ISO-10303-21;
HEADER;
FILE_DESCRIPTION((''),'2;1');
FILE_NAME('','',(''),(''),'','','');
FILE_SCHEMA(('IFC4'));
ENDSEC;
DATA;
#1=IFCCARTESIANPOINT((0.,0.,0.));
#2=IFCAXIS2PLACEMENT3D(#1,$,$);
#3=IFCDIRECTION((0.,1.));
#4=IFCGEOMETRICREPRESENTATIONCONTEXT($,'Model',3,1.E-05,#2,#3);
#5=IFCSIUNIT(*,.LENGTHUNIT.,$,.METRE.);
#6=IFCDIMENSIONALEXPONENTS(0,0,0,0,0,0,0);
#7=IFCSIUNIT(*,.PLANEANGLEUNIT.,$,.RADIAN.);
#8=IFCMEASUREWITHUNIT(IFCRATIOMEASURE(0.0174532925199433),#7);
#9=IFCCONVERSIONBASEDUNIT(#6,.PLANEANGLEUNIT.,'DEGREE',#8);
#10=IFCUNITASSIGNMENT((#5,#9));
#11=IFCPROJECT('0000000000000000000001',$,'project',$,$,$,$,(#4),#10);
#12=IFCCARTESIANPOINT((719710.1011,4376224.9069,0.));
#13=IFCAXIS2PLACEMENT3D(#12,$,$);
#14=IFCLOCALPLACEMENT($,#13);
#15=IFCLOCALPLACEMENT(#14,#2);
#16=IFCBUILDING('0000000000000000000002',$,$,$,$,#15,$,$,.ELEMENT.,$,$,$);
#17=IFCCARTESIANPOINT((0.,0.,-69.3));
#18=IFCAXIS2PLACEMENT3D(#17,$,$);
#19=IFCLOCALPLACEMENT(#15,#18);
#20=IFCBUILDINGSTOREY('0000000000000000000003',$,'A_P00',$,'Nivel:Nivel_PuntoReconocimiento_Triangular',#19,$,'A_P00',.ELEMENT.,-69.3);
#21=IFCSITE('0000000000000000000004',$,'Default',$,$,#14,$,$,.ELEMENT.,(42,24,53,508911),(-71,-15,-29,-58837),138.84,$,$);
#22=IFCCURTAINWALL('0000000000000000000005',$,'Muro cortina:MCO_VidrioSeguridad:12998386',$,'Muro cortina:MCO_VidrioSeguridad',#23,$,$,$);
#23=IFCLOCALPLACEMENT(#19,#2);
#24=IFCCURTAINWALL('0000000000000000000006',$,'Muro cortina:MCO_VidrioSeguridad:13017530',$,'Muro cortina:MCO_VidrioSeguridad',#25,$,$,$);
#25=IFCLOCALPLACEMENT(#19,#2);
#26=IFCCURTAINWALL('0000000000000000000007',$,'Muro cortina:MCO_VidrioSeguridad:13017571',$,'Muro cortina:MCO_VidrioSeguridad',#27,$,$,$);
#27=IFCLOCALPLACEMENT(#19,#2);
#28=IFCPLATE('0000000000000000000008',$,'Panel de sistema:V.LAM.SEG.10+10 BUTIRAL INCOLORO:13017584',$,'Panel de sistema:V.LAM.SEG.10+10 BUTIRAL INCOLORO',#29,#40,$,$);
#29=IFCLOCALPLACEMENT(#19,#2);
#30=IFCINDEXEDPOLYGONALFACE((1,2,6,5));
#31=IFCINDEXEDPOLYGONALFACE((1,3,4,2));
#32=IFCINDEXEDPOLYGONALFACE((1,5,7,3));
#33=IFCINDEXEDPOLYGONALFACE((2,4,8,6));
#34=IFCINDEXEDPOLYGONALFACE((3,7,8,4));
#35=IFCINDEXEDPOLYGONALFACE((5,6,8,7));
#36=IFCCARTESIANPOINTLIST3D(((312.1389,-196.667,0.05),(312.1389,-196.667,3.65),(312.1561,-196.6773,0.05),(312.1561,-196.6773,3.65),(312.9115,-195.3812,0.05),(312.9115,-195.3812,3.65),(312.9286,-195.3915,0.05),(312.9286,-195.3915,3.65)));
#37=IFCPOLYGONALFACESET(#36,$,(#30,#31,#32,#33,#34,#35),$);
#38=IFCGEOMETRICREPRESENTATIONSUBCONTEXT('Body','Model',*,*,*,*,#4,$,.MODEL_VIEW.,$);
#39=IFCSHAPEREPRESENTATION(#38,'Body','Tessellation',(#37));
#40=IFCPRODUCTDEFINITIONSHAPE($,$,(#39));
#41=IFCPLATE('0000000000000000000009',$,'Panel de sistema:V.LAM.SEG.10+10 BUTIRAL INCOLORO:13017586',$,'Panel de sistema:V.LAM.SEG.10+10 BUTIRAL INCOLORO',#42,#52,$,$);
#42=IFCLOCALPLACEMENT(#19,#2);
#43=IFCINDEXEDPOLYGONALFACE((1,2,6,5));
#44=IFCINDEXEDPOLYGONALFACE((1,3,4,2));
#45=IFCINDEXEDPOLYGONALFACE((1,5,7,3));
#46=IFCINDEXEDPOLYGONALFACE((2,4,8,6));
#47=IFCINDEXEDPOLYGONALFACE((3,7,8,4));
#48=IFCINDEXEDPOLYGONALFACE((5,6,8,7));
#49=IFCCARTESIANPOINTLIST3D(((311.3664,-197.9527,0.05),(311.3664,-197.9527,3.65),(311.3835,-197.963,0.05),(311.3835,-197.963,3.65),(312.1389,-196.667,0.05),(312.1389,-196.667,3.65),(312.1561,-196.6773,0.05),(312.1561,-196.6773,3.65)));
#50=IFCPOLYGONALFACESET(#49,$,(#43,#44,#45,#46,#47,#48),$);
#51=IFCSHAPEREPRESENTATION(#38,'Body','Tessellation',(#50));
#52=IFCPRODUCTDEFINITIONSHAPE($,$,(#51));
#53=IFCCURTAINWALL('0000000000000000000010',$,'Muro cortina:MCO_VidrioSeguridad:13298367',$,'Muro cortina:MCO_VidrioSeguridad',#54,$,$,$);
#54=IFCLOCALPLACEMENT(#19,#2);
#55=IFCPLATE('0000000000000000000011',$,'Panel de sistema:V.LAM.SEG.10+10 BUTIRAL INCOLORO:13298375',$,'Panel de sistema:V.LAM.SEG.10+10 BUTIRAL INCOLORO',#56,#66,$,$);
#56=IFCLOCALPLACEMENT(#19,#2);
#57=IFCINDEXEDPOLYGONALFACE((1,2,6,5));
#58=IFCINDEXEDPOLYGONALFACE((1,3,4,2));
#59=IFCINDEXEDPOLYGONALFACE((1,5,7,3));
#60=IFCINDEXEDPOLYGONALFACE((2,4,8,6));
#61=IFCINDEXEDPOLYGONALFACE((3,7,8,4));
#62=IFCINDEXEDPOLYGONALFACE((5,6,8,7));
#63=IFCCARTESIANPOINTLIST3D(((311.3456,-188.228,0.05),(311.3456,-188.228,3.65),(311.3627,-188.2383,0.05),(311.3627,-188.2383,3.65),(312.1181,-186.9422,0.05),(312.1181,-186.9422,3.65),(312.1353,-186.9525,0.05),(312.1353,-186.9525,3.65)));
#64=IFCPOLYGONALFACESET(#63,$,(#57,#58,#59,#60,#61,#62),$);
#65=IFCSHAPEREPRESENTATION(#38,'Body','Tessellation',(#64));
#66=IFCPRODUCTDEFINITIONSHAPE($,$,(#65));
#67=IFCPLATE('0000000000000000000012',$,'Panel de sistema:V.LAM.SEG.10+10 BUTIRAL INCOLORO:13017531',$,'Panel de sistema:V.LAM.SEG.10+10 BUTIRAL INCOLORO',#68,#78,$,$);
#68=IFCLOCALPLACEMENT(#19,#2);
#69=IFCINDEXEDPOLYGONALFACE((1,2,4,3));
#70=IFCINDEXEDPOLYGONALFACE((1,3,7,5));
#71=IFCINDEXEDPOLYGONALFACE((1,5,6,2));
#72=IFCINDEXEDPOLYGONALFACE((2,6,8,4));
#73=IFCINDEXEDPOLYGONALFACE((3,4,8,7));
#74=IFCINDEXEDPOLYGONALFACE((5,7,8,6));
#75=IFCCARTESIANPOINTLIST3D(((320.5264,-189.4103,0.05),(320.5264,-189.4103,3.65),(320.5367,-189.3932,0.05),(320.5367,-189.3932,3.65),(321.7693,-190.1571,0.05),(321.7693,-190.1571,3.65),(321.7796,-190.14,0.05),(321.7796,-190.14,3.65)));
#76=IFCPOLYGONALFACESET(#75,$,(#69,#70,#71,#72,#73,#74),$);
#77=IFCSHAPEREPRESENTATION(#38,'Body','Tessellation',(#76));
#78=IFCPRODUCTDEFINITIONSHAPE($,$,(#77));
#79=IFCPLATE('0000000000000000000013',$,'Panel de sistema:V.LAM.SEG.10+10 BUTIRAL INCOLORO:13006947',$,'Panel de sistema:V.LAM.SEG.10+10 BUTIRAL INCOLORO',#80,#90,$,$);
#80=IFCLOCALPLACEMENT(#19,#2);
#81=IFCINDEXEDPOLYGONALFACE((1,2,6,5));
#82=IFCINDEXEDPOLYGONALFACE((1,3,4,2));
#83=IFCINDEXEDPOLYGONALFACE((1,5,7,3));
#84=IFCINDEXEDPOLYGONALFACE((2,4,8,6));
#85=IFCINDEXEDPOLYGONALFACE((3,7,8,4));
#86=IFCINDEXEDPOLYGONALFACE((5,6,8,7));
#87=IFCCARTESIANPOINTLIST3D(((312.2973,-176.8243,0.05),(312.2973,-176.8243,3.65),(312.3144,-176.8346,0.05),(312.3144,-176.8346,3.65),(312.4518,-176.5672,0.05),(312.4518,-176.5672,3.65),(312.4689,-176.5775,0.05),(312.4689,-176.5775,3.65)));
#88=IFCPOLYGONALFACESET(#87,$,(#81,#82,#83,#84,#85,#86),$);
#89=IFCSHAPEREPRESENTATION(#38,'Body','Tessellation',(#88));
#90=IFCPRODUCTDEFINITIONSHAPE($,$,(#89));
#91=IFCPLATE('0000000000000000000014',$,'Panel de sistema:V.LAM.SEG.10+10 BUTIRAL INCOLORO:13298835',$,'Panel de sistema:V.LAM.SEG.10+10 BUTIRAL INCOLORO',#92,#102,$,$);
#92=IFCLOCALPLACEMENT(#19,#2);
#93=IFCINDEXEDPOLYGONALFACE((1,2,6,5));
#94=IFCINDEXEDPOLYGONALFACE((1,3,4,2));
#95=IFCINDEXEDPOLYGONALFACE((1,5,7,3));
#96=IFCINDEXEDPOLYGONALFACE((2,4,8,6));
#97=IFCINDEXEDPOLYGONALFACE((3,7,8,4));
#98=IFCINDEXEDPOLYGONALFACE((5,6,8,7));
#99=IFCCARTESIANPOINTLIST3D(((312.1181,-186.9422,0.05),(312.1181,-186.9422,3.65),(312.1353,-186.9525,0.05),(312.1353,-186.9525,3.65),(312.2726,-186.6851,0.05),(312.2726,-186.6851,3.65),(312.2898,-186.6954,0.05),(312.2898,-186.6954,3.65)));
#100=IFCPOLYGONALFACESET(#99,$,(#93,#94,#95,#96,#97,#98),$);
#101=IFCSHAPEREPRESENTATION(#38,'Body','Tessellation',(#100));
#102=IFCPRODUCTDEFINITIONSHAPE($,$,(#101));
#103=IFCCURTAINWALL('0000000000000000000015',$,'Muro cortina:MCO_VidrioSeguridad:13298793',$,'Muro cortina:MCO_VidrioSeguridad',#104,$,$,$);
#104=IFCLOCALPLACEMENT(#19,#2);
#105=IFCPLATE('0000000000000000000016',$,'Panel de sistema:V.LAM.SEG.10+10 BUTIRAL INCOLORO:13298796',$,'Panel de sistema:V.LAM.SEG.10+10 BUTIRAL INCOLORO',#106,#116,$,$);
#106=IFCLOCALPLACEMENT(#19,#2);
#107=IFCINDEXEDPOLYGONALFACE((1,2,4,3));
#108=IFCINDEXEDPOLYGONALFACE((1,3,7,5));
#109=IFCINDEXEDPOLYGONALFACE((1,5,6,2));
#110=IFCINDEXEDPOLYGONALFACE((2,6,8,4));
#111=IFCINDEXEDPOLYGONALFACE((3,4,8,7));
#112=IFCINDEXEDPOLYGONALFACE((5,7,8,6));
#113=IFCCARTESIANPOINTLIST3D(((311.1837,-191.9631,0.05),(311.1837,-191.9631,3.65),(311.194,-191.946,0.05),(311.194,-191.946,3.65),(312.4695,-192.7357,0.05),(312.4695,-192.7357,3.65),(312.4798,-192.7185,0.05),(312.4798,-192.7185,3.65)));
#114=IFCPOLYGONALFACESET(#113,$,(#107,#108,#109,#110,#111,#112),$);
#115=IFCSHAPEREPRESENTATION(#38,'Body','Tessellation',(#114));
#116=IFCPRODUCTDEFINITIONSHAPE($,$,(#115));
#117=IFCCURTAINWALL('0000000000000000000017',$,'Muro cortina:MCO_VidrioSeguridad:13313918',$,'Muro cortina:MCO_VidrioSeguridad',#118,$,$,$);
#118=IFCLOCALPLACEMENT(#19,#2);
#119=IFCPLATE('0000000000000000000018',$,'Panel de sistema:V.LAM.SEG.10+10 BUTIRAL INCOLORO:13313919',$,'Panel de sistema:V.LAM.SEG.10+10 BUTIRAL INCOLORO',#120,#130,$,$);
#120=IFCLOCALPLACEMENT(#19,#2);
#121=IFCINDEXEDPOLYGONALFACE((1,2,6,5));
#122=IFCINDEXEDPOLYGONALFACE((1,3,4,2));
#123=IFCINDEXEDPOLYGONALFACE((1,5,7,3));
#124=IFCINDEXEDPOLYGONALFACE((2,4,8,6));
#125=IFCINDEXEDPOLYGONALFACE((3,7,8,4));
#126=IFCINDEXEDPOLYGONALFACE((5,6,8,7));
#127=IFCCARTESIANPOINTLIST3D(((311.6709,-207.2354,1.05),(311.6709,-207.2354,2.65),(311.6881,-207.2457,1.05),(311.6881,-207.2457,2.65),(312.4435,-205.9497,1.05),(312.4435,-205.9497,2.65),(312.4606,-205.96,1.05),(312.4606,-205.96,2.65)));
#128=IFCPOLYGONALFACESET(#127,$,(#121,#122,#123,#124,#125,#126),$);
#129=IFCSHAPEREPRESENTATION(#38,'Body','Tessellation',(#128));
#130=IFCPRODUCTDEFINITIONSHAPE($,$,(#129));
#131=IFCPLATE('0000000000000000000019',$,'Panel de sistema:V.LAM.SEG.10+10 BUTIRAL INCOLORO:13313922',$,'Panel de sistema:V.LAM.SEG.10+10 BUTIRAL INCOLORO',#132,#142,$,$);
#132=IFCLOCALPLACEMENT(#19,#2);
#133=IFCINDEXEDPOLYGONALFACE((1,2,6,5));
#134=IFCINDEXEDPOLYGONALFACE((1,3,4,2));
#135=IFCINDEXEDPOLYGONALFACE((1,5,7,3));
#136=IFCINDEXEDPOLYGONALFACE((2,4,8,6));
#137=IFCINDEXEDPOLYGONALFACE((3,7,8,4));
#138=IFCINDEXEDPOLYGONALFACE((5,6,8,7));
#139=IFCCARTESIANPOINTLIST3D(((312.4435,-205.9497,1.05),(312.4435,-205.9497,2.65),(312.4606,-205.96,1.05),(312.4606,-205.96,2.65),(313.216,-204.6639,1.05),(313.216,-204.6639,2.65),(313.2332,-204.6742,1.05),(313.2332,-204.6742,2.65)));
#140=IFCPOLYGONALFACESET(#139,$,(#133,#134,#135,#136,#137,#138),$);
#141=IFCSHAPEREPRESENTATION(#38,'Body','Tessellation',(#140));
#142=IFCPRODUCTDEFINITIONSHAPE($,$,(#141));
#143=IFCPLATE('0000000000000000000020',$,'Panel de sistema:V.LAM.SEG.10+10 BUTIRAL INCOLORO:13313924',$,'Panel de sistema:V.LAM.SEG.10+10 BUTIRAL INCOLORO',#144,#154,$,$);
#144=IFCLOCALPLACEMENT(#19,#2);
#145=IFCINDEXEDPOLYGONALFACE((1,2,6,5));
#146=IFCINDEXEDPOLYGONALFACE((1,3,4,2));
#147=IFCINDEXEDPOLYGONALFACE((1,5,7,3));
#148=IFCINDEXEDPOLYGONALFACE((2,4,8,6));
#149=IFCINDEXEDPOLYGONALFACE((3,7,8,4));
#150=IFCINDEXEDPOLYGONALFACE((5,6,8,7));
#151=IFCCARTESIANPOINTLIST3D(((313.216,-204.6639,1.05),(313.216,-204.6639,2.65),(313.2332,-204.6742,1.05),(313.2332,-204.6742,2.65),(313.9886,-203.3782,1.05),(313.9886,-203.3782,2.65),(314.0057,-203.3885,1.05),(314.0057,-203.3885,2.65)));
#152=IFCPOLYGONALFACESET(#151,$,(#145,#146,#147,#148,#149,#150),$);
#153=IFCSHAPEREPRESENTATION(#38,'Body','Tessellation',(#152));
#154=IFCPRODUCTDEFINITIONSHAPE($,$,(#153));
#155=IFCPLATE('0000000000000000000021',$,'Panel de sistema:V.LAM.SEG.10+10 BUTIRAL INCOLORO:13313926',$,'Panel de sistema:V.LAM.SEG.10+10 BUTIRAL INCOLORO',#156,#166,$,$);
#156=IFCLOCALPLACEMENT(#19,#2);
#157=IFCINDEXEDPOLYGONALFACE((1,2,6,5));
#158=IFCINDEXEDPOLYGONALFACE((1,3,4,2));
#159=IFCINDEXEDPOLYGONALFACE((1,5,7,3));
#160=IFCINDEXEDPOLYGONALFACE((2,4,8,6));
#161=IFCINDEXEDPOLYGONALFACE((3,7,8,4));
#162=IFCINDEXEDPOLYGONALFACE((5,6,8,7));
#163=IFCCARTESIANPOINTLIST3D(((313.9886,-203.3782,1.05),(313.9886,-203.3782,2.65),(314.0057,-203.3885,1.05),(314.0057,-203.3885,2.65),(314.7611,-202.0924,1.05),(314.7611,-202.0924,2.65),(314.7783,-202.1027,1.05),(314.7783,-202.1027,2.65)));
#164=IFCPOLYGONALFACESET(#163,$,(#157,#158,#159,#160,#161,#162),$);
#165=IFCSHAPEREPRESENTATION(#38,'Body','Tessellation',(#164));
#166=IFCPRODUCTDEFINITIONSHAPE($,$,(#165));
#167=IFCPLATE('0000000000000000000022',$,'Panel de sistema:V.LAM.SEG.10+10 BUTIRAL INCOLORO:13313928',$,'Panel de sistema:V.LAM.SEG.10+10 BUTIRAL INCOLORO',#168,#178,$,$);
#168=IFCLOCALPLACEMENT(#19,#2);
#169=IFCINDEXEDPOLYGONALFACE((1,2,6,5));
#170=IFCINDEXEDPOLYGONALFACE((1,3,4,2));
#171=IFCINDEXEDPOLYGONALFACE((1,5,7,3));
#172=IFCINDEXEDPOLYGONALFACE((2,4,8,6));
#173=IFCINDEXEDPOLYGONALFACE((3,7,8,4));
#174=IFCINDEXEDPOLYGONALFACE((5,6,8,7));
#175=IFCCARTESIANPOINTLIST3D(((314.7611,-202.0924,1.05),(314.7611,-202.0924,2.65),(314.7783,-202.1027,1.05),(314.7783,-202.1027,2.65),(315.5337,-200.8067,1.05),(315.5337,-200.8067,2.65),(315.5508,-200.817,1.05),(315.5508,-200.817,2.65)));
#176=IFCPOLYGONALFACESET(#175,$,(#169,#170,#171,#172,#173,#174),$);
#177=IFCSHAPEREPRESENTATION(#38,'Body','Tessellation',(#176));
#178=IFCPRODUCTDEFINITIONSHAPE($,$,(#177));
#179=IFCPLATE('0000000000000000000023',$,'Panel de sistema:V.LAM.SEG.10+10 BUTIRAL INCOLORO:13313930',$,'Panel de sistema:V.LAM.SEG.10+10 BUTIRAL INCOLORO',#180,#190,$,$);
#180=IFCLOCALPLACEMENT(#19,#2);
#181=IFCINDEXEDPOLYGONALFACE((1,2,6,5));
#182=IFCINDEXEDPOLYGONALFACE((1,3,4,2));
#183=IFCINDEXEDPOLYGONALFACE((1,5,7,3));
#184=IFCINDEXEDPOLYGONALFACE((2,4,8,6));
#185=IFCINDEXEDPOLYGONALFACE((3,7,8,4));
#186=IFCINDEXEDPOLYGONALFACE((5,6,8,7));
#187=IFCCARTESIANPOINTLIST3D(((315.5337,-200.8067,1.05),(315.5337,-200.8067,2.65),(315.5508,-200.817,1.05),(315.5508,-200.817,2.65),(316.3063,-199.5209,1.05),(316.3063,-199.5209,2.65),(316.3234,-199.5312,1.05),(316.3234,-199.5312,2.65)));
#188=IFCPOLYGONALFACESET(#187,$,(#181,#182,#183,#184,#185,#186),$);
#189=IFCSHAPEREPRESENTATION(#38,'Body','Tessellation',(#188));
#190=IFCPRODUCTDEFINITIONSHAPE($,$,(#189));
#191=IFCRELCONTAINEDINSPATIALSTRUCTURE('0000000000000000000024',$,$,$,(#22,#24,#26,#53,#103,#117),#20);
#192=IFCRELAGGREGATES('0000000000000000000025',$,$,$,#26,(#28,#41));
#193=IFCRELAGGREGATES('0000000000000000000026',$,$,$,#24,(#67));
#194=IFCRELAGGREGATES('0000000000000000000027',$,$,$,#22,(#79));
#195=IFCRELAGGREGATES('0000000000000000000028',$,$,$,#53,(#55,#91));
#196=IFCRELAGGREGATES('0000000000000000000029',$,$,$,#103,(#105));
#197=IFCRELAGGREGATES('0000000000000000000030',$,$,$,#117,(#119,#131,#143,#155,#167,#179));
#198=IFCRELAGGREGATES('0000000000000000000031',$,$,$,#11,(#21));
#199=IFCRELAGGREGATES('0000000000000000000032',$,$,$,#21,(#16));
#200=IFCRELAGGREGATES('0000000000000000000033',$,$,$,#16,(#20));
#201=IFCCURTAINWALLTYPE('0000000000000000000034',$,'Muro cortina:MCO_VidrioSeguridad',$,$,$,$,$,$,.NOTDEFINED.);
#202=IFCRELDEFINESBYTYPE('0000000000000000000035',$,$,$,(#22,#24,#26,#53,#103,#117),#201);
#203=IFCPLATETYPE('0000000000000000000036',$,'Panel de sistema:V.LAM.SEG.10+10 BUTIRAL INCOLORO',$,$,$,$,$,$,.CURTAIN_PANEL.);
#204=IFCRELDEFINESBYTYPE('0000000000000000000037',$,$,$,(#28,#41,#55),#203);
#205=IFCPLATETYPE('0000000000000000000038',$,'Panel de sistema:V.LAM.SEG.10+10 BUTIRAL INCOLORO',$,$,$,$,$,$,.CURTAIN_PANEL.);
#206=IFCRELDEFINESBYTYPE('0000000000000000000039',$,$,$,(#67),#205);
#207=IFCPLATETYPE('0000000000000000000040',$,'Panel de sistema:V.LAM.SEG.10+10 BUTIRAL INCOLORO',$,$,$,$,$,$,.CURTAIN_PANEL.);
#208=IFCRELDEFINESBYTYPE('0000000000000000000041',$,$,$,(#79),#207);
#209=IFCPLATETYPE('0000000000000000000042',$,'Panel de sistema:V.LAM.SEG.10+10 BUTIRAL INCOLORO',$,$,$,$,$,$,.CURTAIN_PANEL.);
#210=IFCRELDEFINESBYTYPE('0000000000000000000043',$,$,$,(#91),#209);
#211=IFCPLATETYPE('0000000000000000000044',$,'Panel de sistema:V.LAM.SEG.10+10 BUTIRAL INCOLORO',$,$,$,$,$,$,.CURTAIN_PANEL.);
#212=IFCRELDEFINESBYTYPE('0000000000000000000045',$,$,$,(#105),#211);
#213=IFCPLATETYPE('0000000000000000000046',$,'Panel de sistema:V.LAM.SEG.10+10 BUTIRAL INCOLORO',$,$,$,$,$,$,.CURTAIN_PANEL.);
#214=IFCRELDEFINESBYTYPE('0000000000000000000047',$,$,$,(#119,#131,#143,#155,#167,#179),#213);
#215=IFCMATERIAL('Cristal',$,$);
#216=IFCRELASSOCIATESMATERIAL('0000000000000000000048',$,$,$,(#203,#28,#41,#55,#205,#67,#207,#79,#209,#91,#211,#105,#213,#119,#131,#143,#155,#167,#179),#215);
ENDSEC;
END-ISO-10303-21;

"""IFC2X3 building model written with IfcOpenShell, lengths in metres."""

from ifc_helpers import new_model, entity, si_unit, converted_unit, direction, frame, frame_2d, origin, origin_2d_with_axis, place, context, subcontext, project, spatial, rectangle, extrude, source, transform, mapped, material, type_object, type_shapes, element, aggregate, save


model = new_model("IFC2X3")

# Units and contexts
model_context = context("Model", 3, precision=1e-05, world=origin(), true_north=direction((0.0, 1.0)))
body_context = subcontext(model_context, "Body", "Model", "MODEL_VIEW")
ifc_project = project(units=[si_unit("LENGTHUNIT", "METRE"), converted_unit("PLANEANGLEUNIT", "DEGREE", entity("IfcRatioMeasure", 0.0174532925199433), si_unit("PLANEANGLEUNIT", "RADIAN"), dimensions=[0, 0, 0, 0, 0, 0, 0])], contexts=[model_context])

# Site, building, storey
site_placement = place(None, frame((719710.1011, 4376224.9069, 0.0)))
site = spatial("IfcSite", under=ifc_project, at=site_placement, Name="Default", CompositionType="ELEMENT", RefLatitude=(42, 24, 53, 508911), RefLongitude=(-71, -15, -29, -58837), RefElevation=138.84)
building_placement = place(site_placement, origin())
building = spatial("IfcBuilding", under=site, at=building_placement, CompositionType="ELEMENT")
storey_placement = place(building_placement, frame((0.0, 0.0, -69.3)))
storey = spatial("IfcBuildingStorey", under=building, at=storey_placement, Name="A_P00", ObjectType="Nivel:Nivel_PuntoReconocimiento_Triangular", LongName="A_P00", CompositionType="ELEMENT", Elevation=-69.3)

# Curtain wall
curtain_wall_type = type_object("IfcCurtainWallType", Name="Muro cortina:MCO_VidrioSeguridad", PredefinedType="NOTDEFINED")
curtain_wall_1_placement = place(storey_placement, frame((0.0, 0.0, 69.3)))
curtain_wall_1 = element("IfcCurtainWall", 1, at=curtain_wall_1_placement, inside=storey, type_object=curtain_wall_type, Name="Muro cortina:MCO_VidrioSeguridad:12998386", ObjectType="Muro cortina:MCO_VidrioSeguridad")
ifc_material_1 = material(Name="Cristal")
plate_type_1 = type_object("IfcPlateType", Name="Panel de sistema:V.LAM.SEG.10+10 BUTIRAL INCOLORO", PredefinedType="CURTAIN_PANEL", material=ifc_material_1)
shared_shape_1 = source(origin(), body_context, "Body", "SweptSolid", [
    extrude(rectangle(XDim=0.02, YDim=1.5, at=origin_2d_with_axis()), frame((0.0, 0.0, 0.0), z_axis=(0.0, 0.0, 1.0), x_axis=(0.0, 1.0, 0.0)), (0.0, 0.0, 1.0), 3.6),
])
type_shapes(plate_type_1, [shared_shape_1])

# Curtain walls, plates
curtain_wall_2_placement = place(storey_placement, frame((0.0, 0.0, 69.3)))
curtain_wall_2 = element("IfcCurtainWall", 2, at=curtain_wall_2_placement, inside=storey, type_object=curtain_wall_type, Name="Muro cortina:MCO_VidrioSeguridad:13017530", ObjectType="Muro cortina:MCO_VidrioSeguridad")
curtain_wall_3_placement = place(storey_placement, frame((0.0, 0.0, 69.3)))
curtain_wall_3 = element("IfcCurtainWall", 3, at=curtain_wall_3_placement, inside=storey, type_object=curtain_wall_type, Name="Muro cortina:MCO_VidrioSeguridad:13017571", ObjectType="Muro cortina:MCO_VidrioSeguridad")
plate_1_placement = place(curtain_wall_3_placement, frame((312.5338, -196.0292, -69.25), z_axis=(0.0, 0.0, 1.0), x_axis=(-0.515038, -0.857167, 0.0)))
plate_1 = element("IfcPlate", 4, at=plate_1_placement, type_object=plate_type_1, material=ifc_material_1, Name="Panel de sistema:V.LAM.SEG.10+10 BUTIRAL INCOLORO:13017584", ObjectType="Panel de sistema:V.LAM.SEG.10+10 BUTIRAL INCOLORO", context=body_context, shape_type="MappedRepresentation", body=[
    mapped(shared_shape_1, transform((0.0, 0.0, 0.0), scale=1.0)),
])
plate_2_placement = place(curtain_wall_3_placement, frame((311.7612, -197.315, -69.25), z_axis=(0.0, 0.0, 1.0), x_axis=(-0.515038, -0.857167, 0.0)))
plate_2 = element("IfcPlate", 5, at=plate_2_placement, type_object=plate_type_1, material=ifc_material_1, Name="Panel de sistema:V.LAM.SEG.10+10 BUTIRAL INCOLORO:13017586", ObjectType="Panel de sistema:V.LAM.SEG.10+10 BUTIRAL INCOLORO", context=body_context, shape_type="MappedRepresentation", body=[
    mapped(shared_shape_1, transform((0.0, 0.0, 0.0), scale=1.0)),
])
aggregate(curtain_wall_3, [plate_1, plate_2])

# Curtain wall, plate
curtain_wall_4_placement = place(storey_placement, frame((0.0, 0.0, 69.3)))
curtain_wall_4 = element("IfcCurtainWall", 6, at=curtain_wall_4_placement, inside=storey, type_object=curtain_wall_type, Name="Muro cortina:MCO_VidrioSeguridad:13298367", ObjectType="Muro cortina:MCO_VidrioSeguridad")
plate_3_placement = place(curtain_wall_4_placement, frame((311.7404, -187.5903, -69.25), z_axis=(0.0, 0.0, 1.0), x_axis=(0.515038, 0.857167, 0.0)))
plate_3 = element("IfcPlate", 7, at=plate_3_placement, type_object=plate_type_1, material=ifc_material_1, Name="Panel de sistema:V.LAM.SEG.10+10 BUTIRAL INCOLORO:13298375", ObjectType="Panel de sistema:V.LAM.SEG.10+10 BUTIRAL INCOLORO", context=body_context, shape_type="MappedRepresentation", body=[
    mapped(shared_shape_1, transform((0.0, 0.0, 0.0), scale=1.0)),
])

# Plates
plate_type_2 = type_object("IfcPlateType", Name="Panel de sistema:V.LAM.SEG.10+10 BUTIRAL INCOLORO", PredefinedType="CURTAIN_PANEL", material=ifc_material_1)
shared_shape_2 = source(origin(), body_context, "Body", "SweptSolid", [
    extrude(rectangle(XDim=0.02, YDim=1.45, at=origin_2d_with_axis()), frame((0.0, 0.0, 0.0), z_axis=(0.0, 0.0, 1.0), x_axis=(0.0, 1.0, 0.0)), (0.0, 0.0, 1.0), 3.6),
])
type_shapes(plate_type_2, [shared_shape_2])
plate_4_placement = place(curtain_wall_2_placement, frame((321.153, -189.7752, -69.25), z_axis=(0.0, 0.0, 1.0), x_axis=(-0.857167, 0.515038, 0.0)))
plate_4 = element("IfcPlate", 8, at=plate_4_placement, type_object=plate_type_2, material=ifc_material_1, Name="Panel de sistema:V.LAM.SEG.10+10 BUTIRAL INCOLORO:13017531", ObjectType="Panel de sistema:V.LAM.SEG.10+10 BUTIRAL INCOLORO", context=body_context, shape_type="MappedRepresentation", body=[
    mapped(shared_shape_2, transform((0.0, 0.0, 0.0), scale=1.0)),
])
aggregate(curtain_wall_2, [plate_4])
plate_type_3 = type_object("IfcPlateType", Name="Panel de sistema:V.LAM.SEG.10+10 BUTIRAL INCOLORO", PredefinedType="CURTAIN_PANEL", material=ifc_material_1)
shared_shape_3 = source(origin(), body_context, "Body", "SweptSolid", [
    extrude(rectangle(XDim=0.02, YDim=0.3, at=origin_2d_with_axis()), frame((0.0, 0.0, 0.0), z_axis=(0.0, 0.0, 1.0), x_axis=(0.0, 1.0, 0.0)), (0.0, 0.0, 1.0), 3.6),
])
type_shapes(plate_type_3, [shared_shape_3])
plate_5_placement = place(curtain_wall_1_placement, frame((312.3831, -176.7009, -69.25), z_axis=(0.0, 0.0, 1.0), x_axis=(0.515038, 0.857167, 0.0)))
plate_5 = element("IfcPlate", 9, at=plate_5_placement, type_object=plate_type_3, material=ifc_material_1, Name="Panel de sistema:V.LAM.SEG.10+10 BUTIRAL INCOLORO:13006947", ObjectType="Panel de sistema:V.LAM.SEG.10+10 BUTIRAL INCOLORO", context=body_context, shape_type="MappedRepresentation", body=[
    mapped(shared_shape_3, transform((0.0, 0.0, 0.0), scale=1.0)),
])
aggregate(curtain_wall_1, [plate_5])
plate_type_4 = type_object("IfcPlateType", Name="Panel de sistema:V.LAM.SEG.10+10 BUTIRAL INCOLORO", PredefinedType="CURTAIN_PANEL", material=ifc_material_1)
shared_shape_4 = source(origin(), body_context, "Body", "SweptSolid", [
    extrude(rectangle(XDim=0.02, YDim=0.3, at=origin_2d_with_axis()), frame((0.0, 0.0, 0.0), z_axis=(0.0, 0.0, 1.0), x_axis=(0.0, 1.0, 0.0)), (0.0, 0.0, 1.0), 3.6),
])
type_shapes(plate_type_4, [shared_shape_4])
plate_6_placement = place(curtain_wall_4_placement, frame((312.204, -186.8188, -69.25), z_axis=(0.0, 0.0, 1.0), x_axis=(0.515038, 0.857167, 0.0)))
plate_6 = element("IfcPlate", 10, at=plate_6_placement, type_object=plate_type_4, material=ifc_material_1, Name="Panel de sistema:V.LAM.SEG.10+10 BUTIRAL INCOLORO:13298835", ObjectType="Panel de sistema:V.LAM.SEG.10+10 BUTIRAL INCOLORO", context=body_context, shape_type="MappedRepresentation", body=[
    mapped(shared_shape_4, transform((0.0, 0.0, 0.0), scale=1.0)),
])
aggregate(curtain_wall_4, [plate_3, plate_6])

# Curtain wall, plate
curtain_wall_5_placement = place(storey_placement, frame((0.0, 0.0, 69.3)))
curtain_wall_5 = element("IfcCurtainWall", 11, at=curtain_wall_5_placement, inside=storey, type_object=curtain_wall_type, Name="Muro cortina:MCO_VidrioSeguridad:13298793", ObjectType="Muro cortina:MCO_VidrioSeguridad")
plate_type_5 = type_object("IfcPlateType", Name="Panel de sistema:V.LAM.SEG.10+10 BUTIRAL INCOLORO", PredefinedType="CURTAIN_PANEL", material=ifc_material_1)
shared_shape_5 = source(origin(), body_context, "Body", "SweptSolid", [
    extrude(rectangle(XDim=0.02, YDim=1.5, at=frame_2d((0.0, 0.0), x_axis=(1.0, 0.0))), frame((0.0, 0.0, 0.0), z_axis=(0.0, 0.0, 1.0), x_axis=(0.0, 1.0, 0.0)), (0.0, 0.0, 1.0), 3.6),
])
type_shapes(plate_type_5, [shared_shape_5])
plate_7_placement = place(curtain_wall_5_placement, frame((311.8317, -192.3408, -69.25), z_axis=(0.0, 0.0, 1.0), x_axis=(0.857167, -0.515038, 0.0)))
plate_7 = element("IfcPlate", 12, at=plate_7_placement, type_object=plate_type_5, material=ifc_material_1, Name="Panel de sistema:V.LAM.SEG.10+10 BUTIRAL INCOLORO:13298796", ObjectType="Panel de sistema:V.LAM.SEG.10+10 BUTIRAL INCOLORO", context=body_context, shape_type="MappedRepresentation", body=[
    mapped(shared_shape_5, transform((0.0, 0.0, 0.0), scale=1.0)),
])
aggregate(curtain_wall_5, [plate_7])

# Curtain wall, plates
curtain_wall_6_placement = place(storey_placement, frame((0.0, 0.0, 69.3)))
curtain_wall_6 = element("IfcCurtainWall", 13, at=curtain_wall_6_placement, inside=storey, type_object=curtain_wall_type, Name="Muro cortina:MCO_VidrioSeguridad:13313918", ObjectType="Muro cortina:MCO_VidrioSeguridad")
plate_type_6 = type_object("IfcPlateType", Name="Panel de sistema:V.LAM.SEG.10+10 BUTIRAL INCOLORO", PredefinedType="CURTAIN_PANEL", material=ifc_material_1)
shared_shape_6 = source(origin(), body_context, "Body", "SweptSolid", [
    extrude(rectangle(XDim=0.02, YDim=1.5, at=frame_2d((0.0, 0.0), x_axis=(1.0, 0.0))), frame((0.0, 0.0, 0.0), z_axis=(0.0, 0.0, 1.0), x_axis=(0.0, 1.0, 0.0)), (0.0, 0.0, 1.0), 1.6),
])
type_shapes(plate_type_6, [shared_shape_6])
plate_8_placement = place(curtain_wall_6_placement, frame((312.0658, -206.5977, -68.25), z_axis=(0.0, 0.0, 1.0), x_axis=(0.515038, 0.857167, 0.0)))
plate_8 = element("IfcPlate", 14, at=plate_8_placement, type_object=plate_type_6, material=ifc_material_1, Name="Panel de sistema:V.LAM.SEG.10+10 BUTIRAL INCOLORO:13313919", ObjectType="Panel de sistema:V.LAM.SEG.10+10 BUTIRAL INCOLORO", context=body_context, shape_type="MappedRepresentation", body=[
    mapped(shared_shape_6, transform((0.0, 0.0, 0.0), scale=1.0)),
])
plate_9_placement = place(curtain_wall_6_placement, frame((312.8383, -205.312, -68.25), z_axis=(0.0, 0.0, 1.0), x_axis=(0.515038, 0.857167, 0.0)))
plate_9 = element("IfcPlate", 15, at=plate_9_placement, type_object=plate_type_6, material=ifc_material_1, Name="Panel de sistema:V.LAM.SEG.10+10 BUTIRAL INCOLORO:13313922", ObjectType="Panel de sistema:V.LAM.SEG.10+10 BUTIRAL INCOLORO", context=body_context, shape_type="MappedRepresentation", body=[
    mapped(shared_shape_6, transform((0.0, 0.0, 0.0), scale=1.0)),
])
plate_10_placement = place(curtain_wall_6_placement, frame((313.6109, -204.0262, -68.25), z_axis=(0.0, 0.0, 1.0), x_axis=(0.515038, 0.857167, 0.0)))
plate_10 = element("IfcPlate", 16, at=plate_10_placement, type_object=plate_type_6, material=ifc_material_1, Name="Panel de sistema:V.LAM.SEG.10+10 BUTIRAL INCOLORO:13313924", ObjectType="Panel de sistema:V.LAM.SEG.10+10 BUTIRAL INCOLORO", context=body_context, shape_type="MappedRepresentation", body=[
    mapped(shared_shape_6, transform((0.0, 0.0, 0.0), scale=1.0)),
])
plate_11_placement = place(curtain_wall_6_placement, frame((314.3834, -202.7405, -68.25), z_axis=(0.0, 0.0, 1.0), x_axis=(0.515038, 0.857167, 0.0)))
plate_11 = element("IfcPlate", 17, at=plate_11_placement, type_object=plate_type_6, material=ifc_material_1, Name="Panel de sistema:V.LAM.SEG.10+10 BUTIRAL INCOLORO:13313926", ObjectType="Panel de sistema:V.LAM.SEG.10+10 BUTIRAL INCOLORO", context=body_context, shape_type="MappedRepresentation", body=[
    mapped(shared_shape_6, transform((0.0, 0.0, 0.0), scale=1.0)),
])
plate_12_placement = place(curtain_wall_6_placement, frame((315.156, -201.4547, -68.25), z_axis=(0.0, 0.0, 1.0), x_axis=(0.515038, 0.857167, 0.0)))
plate_12 = element("IfcPlate", 18, at=plate_12_placement, type_object=plate_type_6, material=ifc_material_1, Name="Panel de sistema:V.LAM.SEG.10+10 BUTIRAL INCOLORO:13313928", ObjectType="Panel de sistema:V.LAM.SEG.10+10 BUTIRAL INCOLORO", context=body_context, shape_type="MappedRepresentation", body=[
    mapped(shared_shape_6, transform((0.0, 0.0, 0.0), scale=1.0)),
])
plate_13_placement = place(curtain_wall_6_placement, frame((315.9285, -200.169, -68.25), z_axis=(0.0, 0.0, 1.0), x_axis=(0.515038, 0.857167, 0.0)))
plate_13 = element("IfcPlate", 19, at=plate_13_placement, type_object=plate_type_6, material=ifc_material_1, Name="Panel de sistema:V.LAM.SEG.10+10 BUTIRAL INCOLORO:13313930", ObjectType="Panel de sistema:V.LAM.SEG.10+10 BUTIRAL INCOLORO", context=body_context, shape_type="MappedRepresentation", body=[
    mapped(shared_shape_6, transform((0.0, 0.0, 0.0), scale=1.0)),
])
aggregate(curtain_wall_6, [plate_8, plate_9, plate_10, plate_11, plate_12, plate_13])

save(model, "model.ifc")
